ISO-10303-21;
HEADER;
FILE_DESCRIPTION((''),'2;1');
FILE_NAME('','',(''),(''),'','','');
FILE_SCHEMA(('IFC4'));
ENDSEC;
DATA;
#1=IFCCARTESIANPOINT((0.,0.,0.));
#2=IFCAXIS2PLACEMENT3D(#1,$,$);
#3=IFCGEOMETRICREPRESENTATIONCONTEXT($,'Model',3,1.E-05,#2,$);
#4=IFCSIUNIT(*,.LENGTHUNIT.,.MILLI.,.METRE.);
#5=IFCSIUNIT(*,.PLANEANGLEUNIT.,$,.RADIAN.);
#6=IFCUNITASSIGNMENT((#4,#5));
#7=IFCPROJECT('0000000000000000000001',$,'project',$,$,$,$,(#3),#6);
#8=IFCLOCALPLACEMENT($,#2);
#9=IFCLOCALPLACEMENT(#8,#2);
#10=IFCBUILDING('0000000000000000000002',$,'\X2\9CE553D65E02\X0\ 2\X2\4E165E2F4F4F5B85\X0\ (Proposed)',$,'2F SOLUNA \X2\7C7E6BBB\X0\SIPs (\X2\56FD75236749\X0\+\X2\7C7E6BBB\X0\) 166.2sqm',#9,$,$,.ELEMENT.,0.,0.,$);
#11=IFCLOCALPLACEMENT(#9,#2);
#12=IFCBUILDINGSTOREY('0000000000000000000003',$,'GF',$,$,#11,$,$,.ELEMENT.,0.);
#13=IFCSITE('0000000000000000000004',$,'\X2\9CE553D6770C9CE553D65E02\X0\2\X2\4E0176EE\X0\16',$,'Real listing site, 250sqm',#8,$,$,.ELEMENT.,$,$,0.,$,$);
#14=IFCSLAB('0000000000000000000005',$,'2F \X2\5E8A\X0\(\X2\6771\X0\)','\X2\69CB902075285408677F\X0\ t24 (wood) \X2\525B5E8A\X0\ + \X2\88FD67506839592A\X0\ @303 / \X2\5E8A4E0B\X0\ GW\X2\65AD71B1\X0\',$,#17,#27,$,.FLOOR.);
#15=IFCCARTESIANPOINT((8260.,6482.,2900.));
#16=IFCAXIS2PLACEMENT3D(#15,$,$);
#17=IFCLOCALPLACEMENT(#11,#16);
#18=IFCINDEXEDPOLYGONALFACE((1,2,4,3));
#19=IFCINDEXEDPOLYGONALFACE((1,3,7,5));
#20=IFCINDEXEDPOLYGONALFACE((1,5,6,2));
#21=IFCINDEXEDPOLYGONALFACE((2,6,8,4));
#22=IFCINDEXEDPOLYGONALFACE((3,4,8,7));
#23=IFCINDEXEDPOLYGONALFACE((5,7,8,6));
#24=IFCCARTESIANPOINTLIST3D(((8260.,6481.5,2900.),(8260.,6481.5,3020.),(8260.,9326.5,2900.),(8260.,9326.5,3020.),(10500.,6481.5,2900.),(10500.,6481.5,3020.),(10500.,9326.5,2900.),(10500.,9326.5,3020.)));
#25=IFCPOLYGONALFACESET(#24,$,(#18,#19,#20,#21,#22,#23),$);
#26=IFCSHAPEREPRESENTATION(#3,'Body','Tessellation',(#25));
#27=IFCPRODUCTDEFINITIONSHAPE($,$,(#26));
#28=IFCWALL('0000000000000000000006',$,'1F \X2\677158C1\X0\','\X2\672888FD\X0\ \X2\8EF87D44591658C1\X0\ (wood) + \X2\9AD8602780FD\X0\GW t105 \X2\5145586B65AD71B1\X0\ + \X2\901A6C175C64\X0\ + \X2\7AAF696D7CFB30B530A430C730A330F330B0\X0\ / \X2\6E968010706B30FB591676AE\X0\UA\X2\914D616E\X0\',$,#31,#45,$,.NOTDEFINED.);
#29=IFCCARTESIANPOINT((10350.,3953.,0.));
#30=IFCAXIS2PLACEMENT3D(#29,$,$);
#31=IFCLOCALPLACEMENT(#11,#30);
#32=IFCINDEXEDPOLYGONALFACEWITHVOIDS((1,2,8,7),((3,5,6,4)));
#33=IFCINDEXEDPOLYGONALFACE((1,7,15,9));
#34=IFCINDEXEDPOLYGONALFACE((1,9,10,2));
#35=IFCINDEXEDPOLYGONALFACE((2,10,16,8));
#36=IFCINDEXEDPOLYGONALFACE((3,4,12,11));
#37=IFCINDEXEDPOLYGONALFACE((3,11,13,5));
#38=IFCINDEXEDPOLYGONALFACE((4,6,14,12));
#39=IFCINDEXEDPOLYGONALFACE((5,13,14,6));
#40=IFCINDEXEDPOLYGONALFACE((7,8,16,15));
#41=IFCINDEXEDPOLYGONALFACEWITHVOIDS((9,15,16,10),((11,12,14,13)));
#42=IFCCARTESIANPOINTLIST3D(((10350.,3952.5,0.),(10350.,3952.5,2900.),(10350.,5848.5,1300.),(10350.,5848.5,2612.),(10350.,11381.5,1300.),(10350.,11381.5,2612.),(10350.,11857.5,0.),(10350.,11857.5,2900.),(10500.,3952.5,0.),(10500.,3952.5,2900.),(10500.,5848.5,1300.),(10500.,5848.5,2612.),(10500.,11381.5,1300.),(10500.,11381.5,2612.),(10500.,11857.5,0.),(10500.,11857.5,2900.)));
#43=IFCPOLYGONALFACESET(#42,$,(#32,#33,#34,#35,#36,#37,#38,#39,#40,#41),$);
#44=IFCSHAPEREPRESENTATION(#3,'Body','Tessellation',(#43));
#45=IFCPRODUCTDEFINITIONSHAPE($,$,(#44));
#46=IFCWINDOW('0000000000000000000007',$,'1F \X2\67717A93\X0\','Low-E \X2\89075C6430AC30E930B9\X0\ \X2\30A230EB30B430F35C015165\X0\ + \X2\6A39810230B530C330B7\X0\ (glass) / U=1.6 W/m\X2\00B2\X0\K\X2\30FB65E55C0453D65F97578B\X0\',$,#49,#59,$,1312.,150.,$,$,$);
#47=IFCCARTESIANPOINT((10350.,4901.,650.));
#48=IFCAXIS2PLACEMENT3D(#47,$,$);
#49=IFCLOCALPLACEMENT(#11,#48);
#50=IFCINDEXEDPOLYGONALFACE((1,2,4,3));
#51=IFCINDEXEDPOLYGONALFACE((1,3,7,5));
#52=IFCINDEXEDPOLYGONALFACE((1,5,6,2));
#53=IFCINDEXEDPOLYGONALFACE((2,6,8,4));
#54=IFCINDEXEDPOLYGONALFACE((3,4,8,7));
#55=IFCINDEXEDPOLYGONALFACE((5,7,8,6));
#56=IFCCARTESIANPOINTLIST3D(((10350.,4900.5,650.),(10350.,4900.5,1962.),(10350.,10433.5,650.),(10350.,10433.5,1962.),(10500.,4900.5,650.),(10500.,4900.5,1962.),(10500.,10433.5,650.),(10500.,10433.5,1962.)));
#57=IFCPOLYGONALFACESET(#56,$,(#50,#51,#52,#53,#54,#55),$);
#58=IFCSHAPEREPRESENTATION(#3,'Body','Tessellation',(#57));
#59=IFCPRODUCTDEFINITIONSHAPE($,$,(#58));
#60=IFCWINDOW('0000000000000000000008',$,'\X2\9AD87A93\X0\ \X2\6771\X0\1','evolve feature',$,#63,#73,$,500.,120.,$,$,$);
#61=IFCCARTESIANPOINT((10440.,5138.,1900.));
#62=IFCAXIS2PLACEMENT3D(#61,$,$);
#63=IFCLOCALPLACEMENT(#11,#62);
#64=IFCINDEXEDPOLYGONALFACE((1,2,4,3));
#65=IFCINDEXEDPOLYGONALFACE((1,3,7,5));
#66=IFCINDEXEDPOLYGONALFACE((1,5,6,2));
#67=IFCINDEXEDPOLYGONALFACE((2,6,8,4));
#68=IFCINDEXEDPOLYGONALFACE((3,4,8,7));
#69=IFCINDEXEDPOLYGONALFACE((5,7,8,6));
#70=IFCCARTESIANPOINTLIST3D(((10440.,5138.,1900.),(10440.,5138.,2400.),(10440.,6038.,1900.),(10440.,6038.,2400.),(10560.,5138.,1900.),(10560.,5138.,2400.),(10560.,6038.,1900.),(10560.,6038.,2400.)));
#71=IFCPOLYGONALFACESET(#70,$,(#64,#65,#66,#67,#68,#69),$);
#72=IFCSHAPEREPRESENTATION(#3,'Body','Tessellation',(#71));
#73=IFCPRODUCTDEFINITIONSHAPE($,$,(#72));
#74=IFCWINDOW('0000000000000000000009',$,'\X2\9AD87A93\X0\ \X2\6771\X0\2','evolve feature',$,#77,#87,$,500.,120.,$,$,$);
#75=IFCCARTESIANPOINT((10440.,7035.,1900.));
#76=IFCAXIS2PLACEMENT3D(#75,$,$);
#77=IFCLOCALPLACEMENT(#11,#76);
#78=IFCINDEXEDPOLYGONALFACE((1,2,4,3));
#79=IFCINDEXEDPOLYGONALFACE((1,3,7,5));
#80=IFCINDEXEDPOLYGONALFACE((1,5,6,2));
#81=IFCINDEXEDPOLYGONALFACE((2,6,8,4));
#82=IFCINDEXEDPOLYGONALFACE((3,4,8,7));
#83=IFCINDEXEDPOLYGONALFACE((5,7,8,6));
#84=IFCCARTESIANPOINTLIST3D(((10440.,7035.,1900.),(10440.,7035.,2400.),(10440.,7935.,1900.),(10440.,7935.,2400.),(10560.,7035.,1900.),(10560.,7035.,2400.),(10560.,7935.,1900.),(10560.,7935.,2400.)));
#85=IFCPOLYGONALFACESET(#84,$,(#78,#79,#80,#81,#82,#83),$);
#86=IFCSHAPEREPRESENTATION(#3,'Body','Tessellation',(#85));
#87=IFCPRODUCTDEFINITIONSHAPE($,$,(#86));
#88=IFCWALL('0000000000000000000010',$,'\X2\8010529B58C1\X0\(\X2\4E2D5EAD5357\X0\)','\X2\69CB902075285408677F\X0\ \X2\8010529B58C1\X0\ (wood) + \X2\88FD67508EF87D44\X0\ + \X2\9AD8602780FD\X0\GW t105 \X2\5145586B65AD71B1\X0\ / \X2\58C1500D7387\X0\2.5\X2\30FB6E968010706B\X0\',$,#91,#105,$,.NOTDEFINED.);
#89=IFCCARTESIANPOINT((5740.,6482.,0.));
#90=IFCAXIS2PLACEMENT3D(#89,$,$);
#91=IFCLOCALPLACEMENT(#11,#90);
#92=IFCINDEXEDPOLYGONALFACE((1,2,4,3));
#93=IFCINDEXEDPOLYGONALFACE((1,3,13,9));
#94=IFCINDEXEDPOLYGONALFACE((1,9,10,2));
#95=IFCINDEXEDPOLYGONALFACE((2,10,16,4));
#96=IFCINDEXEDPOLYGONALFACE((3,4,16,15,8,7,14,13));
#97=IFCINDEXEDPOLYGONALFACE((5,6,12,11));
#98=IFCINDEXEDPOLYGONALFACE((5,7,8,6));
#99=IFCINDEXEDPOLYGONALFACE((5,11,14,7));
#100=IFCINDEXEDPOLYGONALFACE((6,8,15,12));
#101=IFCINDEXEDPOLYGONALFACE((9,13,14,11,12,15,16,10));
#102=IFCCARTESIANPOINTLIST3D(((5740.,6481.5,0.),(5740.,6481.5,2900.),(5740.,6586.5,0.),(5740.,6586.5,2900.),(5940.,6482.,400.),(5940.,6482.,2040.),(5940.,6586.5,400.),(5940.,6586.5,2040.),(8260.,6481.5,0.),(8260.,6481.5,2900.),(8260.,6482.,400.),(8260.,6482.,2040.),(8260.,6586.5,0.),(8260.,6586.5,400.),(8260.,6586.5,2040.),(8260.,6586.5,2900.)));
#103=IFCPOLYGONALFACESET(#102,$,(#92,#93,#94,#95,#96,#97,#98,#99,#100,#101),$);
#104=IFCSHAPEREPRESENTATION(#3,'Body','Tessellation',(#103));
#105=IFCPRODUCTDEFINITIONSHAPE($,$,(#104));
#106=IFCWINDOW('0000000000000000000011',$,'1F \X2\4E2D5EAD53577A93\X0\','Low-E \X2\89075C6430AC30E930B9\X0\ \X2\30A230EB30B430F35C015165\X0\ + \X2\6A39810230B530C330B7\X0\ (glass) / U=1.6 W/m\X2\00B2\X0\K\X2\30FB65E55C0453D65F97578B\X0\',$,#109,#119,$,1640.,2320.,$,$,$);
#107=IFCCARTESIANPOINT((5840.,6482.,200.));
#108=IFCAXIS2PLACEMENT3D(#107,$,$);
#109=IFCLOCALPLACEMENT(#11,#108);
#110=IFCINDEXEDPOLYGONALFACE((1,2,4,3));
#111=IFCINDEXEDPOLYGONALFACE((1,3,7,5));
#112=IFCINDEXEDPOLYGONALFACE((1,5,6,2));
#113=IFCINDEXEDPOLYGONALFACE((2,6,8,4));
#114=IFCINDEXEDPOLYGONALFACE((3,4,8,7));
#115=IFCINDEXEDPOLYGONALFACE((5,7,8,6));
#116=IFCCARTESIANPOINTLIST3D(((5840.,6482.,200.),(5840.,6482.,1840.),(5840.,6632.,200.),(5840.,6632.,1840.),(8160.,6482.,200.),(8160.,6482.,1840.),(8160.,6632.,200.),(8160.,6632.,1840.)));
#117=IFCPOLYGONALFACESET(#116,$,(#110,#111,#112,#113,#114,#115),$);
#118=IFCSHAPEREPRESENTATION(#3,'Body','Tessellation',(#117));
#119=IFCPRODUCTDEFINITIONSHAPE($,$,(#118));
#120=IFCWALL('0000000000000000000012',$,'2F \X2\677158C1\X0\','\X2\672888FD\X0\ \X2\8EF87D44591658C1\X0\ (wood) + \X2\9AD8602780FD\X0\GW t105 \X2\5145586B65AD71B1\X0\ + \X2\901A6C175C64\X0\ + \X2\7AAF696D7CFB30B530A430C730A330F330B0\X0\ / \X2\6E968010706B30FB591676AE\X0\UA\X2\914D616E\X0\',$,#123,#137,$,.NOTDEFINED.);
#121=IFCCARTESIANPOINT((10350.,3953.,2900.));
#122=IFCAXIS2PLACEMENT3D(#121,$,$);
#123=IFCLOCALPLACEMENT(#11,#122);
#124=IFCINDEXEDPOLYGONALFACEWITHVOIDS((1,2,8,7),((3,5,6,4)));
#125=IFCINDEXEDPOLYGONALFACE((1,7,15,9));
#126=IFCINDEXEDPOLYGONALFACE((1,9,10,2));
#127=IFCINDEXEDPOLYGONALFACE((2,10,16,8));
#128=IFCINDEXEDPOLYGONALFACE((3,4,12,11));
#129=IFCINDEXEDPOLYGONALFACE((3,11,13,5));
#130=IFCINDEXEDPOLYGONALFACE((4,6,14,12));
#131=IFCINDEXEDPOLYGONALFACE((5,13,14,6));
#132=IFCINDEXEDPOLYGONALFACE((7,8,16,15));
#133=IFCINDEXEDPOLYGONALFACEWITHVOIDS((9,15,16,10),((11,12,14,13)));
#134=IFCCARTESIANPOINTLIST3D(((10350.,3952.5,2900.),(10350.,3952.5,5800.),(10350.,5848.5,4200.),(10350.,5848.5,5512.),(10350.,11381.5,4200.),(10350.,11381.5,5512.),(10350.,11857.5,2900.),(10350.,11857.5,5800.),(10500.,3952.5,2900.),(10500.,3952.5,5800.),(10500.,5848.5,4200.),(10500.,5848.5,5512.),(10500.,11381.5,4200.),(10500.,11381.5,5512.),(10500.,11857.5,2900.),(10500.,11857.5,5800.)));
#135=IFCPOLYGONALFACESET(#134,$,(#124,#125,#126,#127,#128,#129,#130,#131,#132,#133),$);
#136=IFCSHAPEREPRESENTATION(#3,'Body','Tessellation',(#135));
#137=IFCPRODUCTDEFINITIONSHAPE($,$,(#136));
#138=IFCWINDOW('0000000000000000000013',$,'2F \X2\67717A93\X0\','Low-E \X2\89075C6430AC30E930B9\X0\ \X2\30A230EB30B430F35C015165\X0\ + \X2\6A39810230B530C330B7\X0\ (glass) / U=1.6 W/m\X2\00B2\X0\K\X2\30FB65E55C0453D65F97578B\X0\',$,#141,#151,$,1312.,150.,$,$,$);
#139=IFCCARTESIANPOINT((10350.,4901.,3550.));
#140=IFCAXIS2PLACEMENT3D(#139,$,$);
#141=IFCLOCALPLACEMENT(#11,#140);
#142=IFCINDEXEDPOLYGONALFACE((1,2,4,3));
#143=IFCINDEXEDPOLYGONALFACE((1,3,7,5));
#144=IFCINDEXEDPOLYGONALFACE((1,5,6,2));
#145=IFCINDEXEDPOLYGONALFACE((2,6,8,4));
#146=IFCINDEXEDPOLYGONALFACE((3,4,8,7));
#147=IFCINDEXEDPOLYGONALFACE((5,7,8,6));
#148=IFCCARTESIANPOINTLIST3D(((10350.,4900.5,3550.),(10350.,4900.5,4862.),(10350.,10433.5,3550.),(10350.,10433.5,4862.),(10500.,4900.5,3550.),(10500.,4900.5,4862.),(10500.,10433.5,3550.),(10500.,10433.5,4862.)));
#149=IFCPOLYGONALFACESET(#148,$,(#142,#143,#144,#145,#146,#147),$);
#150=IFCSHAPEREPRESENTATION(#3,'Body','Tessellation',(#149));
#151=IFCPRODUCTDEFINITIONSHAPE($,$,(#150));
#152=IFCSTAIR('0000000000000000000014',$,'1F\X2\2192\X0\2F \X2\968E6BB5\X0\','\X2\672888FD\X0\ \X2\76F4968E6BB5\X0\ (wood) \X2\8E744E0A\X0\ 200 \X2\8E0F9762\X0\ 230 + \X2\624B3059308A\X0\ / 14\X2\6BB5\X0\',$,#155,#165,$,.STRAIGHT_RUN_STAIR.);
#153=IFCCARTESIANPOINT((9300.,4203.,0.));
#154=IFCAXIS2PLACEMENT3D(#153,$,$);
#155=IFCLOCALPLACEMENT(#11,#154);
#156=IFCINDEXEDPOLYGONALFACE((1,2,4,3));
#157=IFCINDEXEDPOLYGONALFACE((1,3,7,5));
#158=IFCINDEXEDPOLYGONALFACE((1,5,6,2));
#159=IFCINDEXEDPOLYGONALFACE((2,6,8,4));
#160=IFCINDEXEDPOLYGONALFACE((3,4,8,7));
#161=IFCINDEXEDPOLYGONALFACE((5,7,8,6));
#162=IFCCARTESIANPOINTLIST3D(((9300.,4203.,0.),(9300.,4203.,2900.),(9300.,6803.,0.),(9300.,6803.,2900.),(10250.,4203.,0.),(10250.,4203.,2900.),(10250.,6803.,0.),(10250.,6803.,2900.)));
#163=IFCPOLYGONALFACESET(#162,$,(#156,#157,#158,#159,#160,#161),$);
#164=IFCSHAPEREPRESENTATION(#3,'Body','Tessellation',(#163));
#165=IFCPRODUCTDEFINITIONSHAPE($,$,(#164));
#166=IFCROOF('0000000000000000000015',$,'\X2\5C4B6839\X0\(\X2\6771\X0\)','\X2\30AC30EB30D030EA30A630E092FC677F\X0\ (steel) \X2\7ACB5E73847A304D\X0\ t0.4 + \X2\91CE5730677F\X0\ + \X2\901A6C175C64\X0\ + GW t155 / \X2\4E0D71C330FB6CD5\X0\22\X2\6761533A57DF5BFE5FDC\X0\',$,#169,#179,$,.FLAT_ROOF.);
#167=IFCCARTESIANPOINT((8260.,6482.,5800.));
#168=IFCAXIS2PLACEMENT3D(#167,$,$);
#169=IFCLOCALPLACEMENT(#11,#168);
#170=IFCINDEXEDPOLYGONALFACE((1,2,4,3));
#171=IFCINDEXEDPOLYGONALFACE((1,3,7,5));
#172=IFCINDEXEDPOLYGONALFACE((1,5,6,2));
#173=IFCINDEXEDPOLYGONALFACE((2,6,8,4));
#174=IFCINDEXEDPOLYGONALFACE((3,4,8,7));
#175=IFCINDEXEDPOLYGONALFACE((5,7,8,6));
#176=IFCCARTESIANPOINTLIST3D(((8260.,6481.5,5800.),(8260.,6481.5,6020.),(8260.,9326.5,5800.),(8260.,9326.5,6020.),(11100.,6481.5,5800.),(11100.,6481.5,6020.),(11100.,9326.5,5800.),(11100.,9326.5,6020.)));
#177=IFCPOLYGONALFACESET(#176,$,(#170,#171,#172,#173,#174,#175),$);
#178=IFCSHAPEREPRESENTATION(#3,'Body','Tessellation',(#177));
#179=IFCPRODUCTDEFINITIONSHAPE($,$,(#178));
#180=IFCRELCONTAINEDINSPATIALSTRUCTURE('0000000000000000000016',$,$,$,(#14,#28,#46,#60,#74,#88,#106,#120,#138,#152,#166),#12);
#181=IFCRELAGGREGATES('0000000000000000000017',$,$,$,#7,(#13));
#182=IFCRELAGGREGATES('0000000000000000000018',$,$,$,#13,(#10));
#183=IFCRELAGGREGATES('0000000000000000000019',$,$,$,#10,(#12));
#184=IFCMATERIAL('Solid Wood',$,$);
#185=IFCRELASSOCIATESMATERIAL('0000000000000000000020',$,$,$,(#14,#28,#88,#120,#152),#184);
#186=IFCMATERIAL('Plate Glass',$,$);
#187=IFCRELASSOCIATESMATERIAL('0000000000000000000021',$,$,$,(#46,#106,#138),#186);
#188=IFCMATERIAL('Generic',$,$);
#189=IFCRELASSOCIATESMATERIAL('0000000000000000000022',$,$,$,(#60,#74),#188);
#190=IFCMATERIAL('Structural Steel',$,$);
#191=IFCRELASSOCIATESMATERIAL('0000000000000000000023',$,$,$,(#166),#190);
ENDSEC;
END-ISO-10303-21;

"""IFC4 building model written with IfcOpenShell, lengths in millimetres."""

from ifc_helpers import new_model, si_unit, frame, frame_2d, origin, place, context, project, spatial, rectangle, extrude, material, element, fill, save


model = new_model("IFC4")

# Units and contexts
model_context = context("Model", 3, precision=1e-05, world=origin())
ifc_project = project(units=[si_unit("LENGTHUNIT", "METRE", prefix="MILLI"), si_unit("PLANEANGLEUNIT", "RADIAN")], contexts=[model_context])

# Site, building, storey
site_placement = place(None, origin())
site = spatial("IfcSite", under=ifc_project, at=site_placement, Name="鳥取県鳥取市2丁目16", ObjectType="Real listing site, 250sqm", CompositionType="ELEMENT", RefElevation=0.0)
building_placement = place(site_placement, origin())
building = spatial("IfcBuilding", under=site, at=building_placement, Name="鳥取市 2世帯住宅 (Proposed)", ObjectType="2F SOLUNA 籾殻SIPs (国産杉+籾殻) 166.2sqm", CompositionType="ELEMENT", ElevationOfRefHeight=0.0, ElevationOfTerrain=0.0)
storey_placement = place(building_placement, origin())
storey = spatial("IfcBuildingStorey", under=building, at=storey_placement, Name="GF", CompositionType="ELEMENT", Elevation=0.0)

# Slab
ifc_material_1 = material(Name="Solid Wood")
slab_1_placement = place(storey_placement, frame((8260.0, 6482.0, 2900.0)))
element("IfcSlab", 1, at=slab_1_placement, inside=storey, material=ifc_material_1, Name="2F 床(東)", Description="構造用合板 t24 (wood) 剛床 + 製材根太 @303 / 床下 GW断熱", PredefinedType="FLOOR", context=model_context, shape_type="SweptSolid", body=[
    extrude(rectangle(XDim=2240.0, YDim=2845.0, at=frame_2d((1120.0, 1422.0))), frame((8260.0, 6482.0, 2900.0)), (0.0, 0.0, 1.0), 120.0),
])

# Wall, openings, windows
wall_1_placement = place(storey_placement, frame((10350.0, 3953.0, 0.0)))
wall_1 = element("IfcWall", 2, at=wall_1_placement, inside=storey, material=ifc_material_1, Name="1F 東壁", Description="木製 軸組外壁 (wood) + 高性能GW t105 充填断熱 + 通気層 + 窯業系サイディング / 準耐火・外皮UA配慮", PredefinedType="NOTDEFINED", context=model_context, shape_type="SweptSolid", body=[
    extrude(rectangle(XDim=150.0, YDim=7905.0, at=frame_2d((75.0, 3952.0))), frame((10350.0, 3953.0, 0.0)), (0.0, 0.0, 1.0), 2900.0),
])
opening_1_placement = place(storey_placement, frame((10350.0, 4901.0, 650.0)))
opening_1 = element("IfcOpeningElement", 3, at=opening_1_placement, cuts=wall_1, PredefinedType="NOTDEFINED", context=model_context, shape_type="SweptSolid", body=[
    extrude(rectangle(XDim=150.0, YDim=5533.0, at=frame_2d((75.0, 2766.0))), frame((10350.0, 4901.0, 650.0)), (0.0, 0.0, 1.0), 1312.0),
])
opening_2_placement = place(storey_placement, frame((10440.0, 5138.0, 1900.0)))
opening_2 = element("IfcOpeningElement", 4, at=opening_2_placement, cuts=wall_1, PredefinedType="NOTDEFINED", context=model_context, shape_type="SweptSolid", body=[
    extrude(rectangle(XDim=120.0, YDim=900.0, at=frame_2d((60.0, 450.0))), frame((10440.0, 5138.0, 1900.0)), (0.0, 0.0, 1.0), 500.0),
])
opening_3_placement = place(storey_placement, frame((10440.0, 7035.0, 1900.0)))
opening_3 = element("IfcOpeningElement", 5, at=opening_3_placement, cuts=wall_1, PredefinedType="NOTDEFINED", context=model_context, shape_type="SweptSolid", body=[
    extrude(rectangle(XDim=120.0, YDim=900.0, at=frame_2d((60.0, 450.0))), frame((10440.0, 7035.0, 1900.0)), (0.0, 0.0, 1.0), 500.0),
])
ifc_material_2 = material(Name="Plate Glass")
window_1_placement = place(storey_placement, frame((10350.0, 4901.0, 650.0)))
window_1 = element("IfcWindow", 6, at=window_1_placement, inside=storey, material=ifc_material_2, Name="1F 東窓", Description="Low-E 複層ガラス アルゴン封入 + 樹脂サッシ (glass) / U=1.6 W/m²K・日射取得型", OverallHeight=1312.0, OverallWidth=150.0, context=model_context, shape_type="SweptSolid", body=[
    extrude(rectangle(XDim=150.0, YDim=5533.0, at=frame_2d((75.0, 2766.0))), frame((10350.0, 4901.0, 650.0)), (0.0, 0.0, 1.0), 1312.0),
])
fill(opening_1, window_1)
ifc_material_3 = material(Name="Generic")
window_2_placement = place(storey_placement, frame((10440.0, 5138.0, 1900.0)))
window_2 = element("IfcWindow", 7, at=window_2_placement, inside=storey, material=ifc_material_3, Name="高窓 東1", Description="evolve feature", OverallHeight=500.0, OverallWidth=120.0, context=model_context, shape_type="SweptSolid", body=[
    extrude(rectangle(XDim=120.0, YDim=900.0, at=frame_2d((60.0, 450.0))), frame((10440.0, 5138.0, 1900.0)), (0.0, 0.0, 1.0), 500.0),
])
fill(opening_2, window_2)
window_3_placement = place(storey_placement, frame((10440.0, 7035.0, 1900.0)))
window_3 = element("IfcWindow", 8, at=window_3_placement, inside=storey, material=ifc_material_3, Name="高窓 東2", Description="evolve feature", OverallHeight=500.0, OverallWidth=120.0, context=model_context, shape_type="SweptSolid", body=[
    extrude(rectangle(XDim=120.0, YDim=900.0, at=frame_2d((60.0, 450.0))), frame((10440.0, 7035.0, 1900.0)), (0.0, 0.0, 1.0), 500.0),
])
fill(opening_3, window_3)

# Wall, opening, window
wall_2_placement = place(storey_placement, frame((5740.0, 6482.0, 0.0)))
wall_2 = element("IfcWall", 9, at=wall_2_placement, inside=storey, material=ifc_material_1, Name="耐力壁(中庭南)", Description="構造用合板 耐力壁 (wood) + 製材軸組 + 高性能GW t105 充填断熱 / 壁倍率2.5・準耐火", PredefinedType="NOTDEFINED", context=model_context, shape_type="SweptSolid", body=[
    extrude(rectangle(XDim=2520.0, YDim=105.0, at=frame_2d((1260.0, 52.0))), frame((5740.0, 6482.0, 0.0)), (0.0, 0.0, 1.0), 2900.0),
])
opening_4_placement = place(storey_placement, frame((5840.0, 6482.0, 200.0)))
opening_4 = element("IfcOpeningElement", 10, at=opening_4_placement, cuts=wall_2, PredefinedType="NOTDEFINED", context=model_context, shape_type="SweptSolid", body=[
    extrude(rectangle(XDim=2320.0, YDim=150.0, at=frame_2d((1160.0, 75.0))), frame((5840.0, 6482.0, 200.0)), (0.0, 0.0, 1.0), 1640.0),
])
window_4_placement = place(storey_placement, frame((5840.0, 6482.0, 200.0)))
window_4 = element("IfcWindow", 11, at=window_4_placement, inside=storey, material=ifc_material_2, Name="1F 中庭南窓", Description="Low-E 複層ガラス アルゴン封入 + 樹脂サッシ (glass) / U=1.6 W/m²K・日射取得型", OverallHeight=1640.0, OverallWidth=2320.0, context=model_context, shape_type="SweptSolid", body=[
    extrude(rectangle(XDim=2320.0, YDim=150.0, at=frame_2d((1160.0, 75.0))), frame((5840.0, 6482.0, 200.0)), (0.0, 0.0, 1.0), 1640.0),
])
fill(opening_4, window_4)

# Wall, opening, window
wall_3_placement = place(storey_placement, frame((10350.0, 3953.0, 2900.0)))
wall_3 = element("IfcWall", 12, at=wall_3_placement, inside=storey, material=ifc_material_1, Name="2F 東壁", Description="木製 軸組外壁 (wood) + 高性能GW t105 充填断熱 + 通気層 + 窯業系サイディング / 準耐火・外皮UA配慮", PredefinedType="NOTDEFINED", context=model_context, shape_type="SweptSolid", body=[
    extrude(rectangle(XDim=150.0, YDim=7905.0, at=frame_2d((75.0, 3952.0))), frame((10350.0, 3953.0, 2900.0)), (0.0, 0.0, 1.0), 2900.0),
])
opening_5_placement = place(storey_placement, frame((10350.0, 4901.0, 3550.0)))
opening_5 = element("IfcOpeningElement", 13, at=opening_5_placement, cuts=wall_3, PredefinedType="NOTDEFINED", context=model_context, shape_type="SweptSolid", body=[
    extrude(rectangle(XDim=150.0, YDim=5533.0, at=frame_2d((75.0, 2766.0))), frame((10350.0, 4901.0, 3550.0)), (0.0, 0.0, 1.0), 1312.0),
])
window_5_placement = place(storey_placement, frame((10350.0, 4901.0, 3550.0)))
window_5 = element("IfcWindow", 14, at=window_5_placement, inside=storey, material=ifc_material_2, Name="2F 東窓", Description="Low-E 複層ガラス アルゴン封入 + 樹脂サッシ (glass) / U=1.6 W/m²K・日射取得型", OverallHeight=1312.0, OverallWidth=150.0, context=model_context, shape_type="SweptSolid", body=[
    extrude(rectangle(XDim=150.0, YDim=5533.0, at=frame_2d((75.0, 2766.0))), frame((10350.0, 4901.0, 3550.0)), (0.0, 0.0, 1.0), 1312.0),
])
fill(opening_5, window_5)

# Stair
stair_placement = place(storey_placement, frame((9300.0, 4203.0, 0.0)))
element("IfcStair", 15, at=stair_placement, inside=storey, material=ifc_material_1, Name="1F→2F 階段", Description="木製 直階段 (wood) 蹴上 200 踏面 230 + 手すり / 14段", PredefinedType="STRAIGHT_RUN_STAIR", context=model_context, shape_type="SweptSolid", body=[
    extrude(rectangle(XDim=950.0, YDim=2600.0, at=frame_2d((475.0, 1300.0))), frame((9300.0, 4203.0, 0.0)), (0.0, 0.0, 1.0), 2900.0),
])

# Roof
ifc_material_4 = material(Name="Structural Steel")
roof_placement = place(storey_placement, frame((8260.0, 6482.0, 5800.0)))
element("IfcRoof", 16, at=roof_placement, inside=storey, material=ifc_material_4, Name="屋根(東)", Description="ガルバリウム鋼板 (steel) 立平葺き t0.4 + 野地板 + 通気層 + GW t155 / 不燃・法22条区域対応", PredefinedType="FLAT_ROOF", context=model_context, shape_type="SweptSolid", body=[
    extrude(rectangle(XDim=2840.0, YDim=2845.0, at=frame_2d((1420.0, 1422.0))), frame((8260.0, 6482.0, 5800.0)), (0.0, 0.0, 1.0), 220.0),
])

save(model, "model.ifc")
